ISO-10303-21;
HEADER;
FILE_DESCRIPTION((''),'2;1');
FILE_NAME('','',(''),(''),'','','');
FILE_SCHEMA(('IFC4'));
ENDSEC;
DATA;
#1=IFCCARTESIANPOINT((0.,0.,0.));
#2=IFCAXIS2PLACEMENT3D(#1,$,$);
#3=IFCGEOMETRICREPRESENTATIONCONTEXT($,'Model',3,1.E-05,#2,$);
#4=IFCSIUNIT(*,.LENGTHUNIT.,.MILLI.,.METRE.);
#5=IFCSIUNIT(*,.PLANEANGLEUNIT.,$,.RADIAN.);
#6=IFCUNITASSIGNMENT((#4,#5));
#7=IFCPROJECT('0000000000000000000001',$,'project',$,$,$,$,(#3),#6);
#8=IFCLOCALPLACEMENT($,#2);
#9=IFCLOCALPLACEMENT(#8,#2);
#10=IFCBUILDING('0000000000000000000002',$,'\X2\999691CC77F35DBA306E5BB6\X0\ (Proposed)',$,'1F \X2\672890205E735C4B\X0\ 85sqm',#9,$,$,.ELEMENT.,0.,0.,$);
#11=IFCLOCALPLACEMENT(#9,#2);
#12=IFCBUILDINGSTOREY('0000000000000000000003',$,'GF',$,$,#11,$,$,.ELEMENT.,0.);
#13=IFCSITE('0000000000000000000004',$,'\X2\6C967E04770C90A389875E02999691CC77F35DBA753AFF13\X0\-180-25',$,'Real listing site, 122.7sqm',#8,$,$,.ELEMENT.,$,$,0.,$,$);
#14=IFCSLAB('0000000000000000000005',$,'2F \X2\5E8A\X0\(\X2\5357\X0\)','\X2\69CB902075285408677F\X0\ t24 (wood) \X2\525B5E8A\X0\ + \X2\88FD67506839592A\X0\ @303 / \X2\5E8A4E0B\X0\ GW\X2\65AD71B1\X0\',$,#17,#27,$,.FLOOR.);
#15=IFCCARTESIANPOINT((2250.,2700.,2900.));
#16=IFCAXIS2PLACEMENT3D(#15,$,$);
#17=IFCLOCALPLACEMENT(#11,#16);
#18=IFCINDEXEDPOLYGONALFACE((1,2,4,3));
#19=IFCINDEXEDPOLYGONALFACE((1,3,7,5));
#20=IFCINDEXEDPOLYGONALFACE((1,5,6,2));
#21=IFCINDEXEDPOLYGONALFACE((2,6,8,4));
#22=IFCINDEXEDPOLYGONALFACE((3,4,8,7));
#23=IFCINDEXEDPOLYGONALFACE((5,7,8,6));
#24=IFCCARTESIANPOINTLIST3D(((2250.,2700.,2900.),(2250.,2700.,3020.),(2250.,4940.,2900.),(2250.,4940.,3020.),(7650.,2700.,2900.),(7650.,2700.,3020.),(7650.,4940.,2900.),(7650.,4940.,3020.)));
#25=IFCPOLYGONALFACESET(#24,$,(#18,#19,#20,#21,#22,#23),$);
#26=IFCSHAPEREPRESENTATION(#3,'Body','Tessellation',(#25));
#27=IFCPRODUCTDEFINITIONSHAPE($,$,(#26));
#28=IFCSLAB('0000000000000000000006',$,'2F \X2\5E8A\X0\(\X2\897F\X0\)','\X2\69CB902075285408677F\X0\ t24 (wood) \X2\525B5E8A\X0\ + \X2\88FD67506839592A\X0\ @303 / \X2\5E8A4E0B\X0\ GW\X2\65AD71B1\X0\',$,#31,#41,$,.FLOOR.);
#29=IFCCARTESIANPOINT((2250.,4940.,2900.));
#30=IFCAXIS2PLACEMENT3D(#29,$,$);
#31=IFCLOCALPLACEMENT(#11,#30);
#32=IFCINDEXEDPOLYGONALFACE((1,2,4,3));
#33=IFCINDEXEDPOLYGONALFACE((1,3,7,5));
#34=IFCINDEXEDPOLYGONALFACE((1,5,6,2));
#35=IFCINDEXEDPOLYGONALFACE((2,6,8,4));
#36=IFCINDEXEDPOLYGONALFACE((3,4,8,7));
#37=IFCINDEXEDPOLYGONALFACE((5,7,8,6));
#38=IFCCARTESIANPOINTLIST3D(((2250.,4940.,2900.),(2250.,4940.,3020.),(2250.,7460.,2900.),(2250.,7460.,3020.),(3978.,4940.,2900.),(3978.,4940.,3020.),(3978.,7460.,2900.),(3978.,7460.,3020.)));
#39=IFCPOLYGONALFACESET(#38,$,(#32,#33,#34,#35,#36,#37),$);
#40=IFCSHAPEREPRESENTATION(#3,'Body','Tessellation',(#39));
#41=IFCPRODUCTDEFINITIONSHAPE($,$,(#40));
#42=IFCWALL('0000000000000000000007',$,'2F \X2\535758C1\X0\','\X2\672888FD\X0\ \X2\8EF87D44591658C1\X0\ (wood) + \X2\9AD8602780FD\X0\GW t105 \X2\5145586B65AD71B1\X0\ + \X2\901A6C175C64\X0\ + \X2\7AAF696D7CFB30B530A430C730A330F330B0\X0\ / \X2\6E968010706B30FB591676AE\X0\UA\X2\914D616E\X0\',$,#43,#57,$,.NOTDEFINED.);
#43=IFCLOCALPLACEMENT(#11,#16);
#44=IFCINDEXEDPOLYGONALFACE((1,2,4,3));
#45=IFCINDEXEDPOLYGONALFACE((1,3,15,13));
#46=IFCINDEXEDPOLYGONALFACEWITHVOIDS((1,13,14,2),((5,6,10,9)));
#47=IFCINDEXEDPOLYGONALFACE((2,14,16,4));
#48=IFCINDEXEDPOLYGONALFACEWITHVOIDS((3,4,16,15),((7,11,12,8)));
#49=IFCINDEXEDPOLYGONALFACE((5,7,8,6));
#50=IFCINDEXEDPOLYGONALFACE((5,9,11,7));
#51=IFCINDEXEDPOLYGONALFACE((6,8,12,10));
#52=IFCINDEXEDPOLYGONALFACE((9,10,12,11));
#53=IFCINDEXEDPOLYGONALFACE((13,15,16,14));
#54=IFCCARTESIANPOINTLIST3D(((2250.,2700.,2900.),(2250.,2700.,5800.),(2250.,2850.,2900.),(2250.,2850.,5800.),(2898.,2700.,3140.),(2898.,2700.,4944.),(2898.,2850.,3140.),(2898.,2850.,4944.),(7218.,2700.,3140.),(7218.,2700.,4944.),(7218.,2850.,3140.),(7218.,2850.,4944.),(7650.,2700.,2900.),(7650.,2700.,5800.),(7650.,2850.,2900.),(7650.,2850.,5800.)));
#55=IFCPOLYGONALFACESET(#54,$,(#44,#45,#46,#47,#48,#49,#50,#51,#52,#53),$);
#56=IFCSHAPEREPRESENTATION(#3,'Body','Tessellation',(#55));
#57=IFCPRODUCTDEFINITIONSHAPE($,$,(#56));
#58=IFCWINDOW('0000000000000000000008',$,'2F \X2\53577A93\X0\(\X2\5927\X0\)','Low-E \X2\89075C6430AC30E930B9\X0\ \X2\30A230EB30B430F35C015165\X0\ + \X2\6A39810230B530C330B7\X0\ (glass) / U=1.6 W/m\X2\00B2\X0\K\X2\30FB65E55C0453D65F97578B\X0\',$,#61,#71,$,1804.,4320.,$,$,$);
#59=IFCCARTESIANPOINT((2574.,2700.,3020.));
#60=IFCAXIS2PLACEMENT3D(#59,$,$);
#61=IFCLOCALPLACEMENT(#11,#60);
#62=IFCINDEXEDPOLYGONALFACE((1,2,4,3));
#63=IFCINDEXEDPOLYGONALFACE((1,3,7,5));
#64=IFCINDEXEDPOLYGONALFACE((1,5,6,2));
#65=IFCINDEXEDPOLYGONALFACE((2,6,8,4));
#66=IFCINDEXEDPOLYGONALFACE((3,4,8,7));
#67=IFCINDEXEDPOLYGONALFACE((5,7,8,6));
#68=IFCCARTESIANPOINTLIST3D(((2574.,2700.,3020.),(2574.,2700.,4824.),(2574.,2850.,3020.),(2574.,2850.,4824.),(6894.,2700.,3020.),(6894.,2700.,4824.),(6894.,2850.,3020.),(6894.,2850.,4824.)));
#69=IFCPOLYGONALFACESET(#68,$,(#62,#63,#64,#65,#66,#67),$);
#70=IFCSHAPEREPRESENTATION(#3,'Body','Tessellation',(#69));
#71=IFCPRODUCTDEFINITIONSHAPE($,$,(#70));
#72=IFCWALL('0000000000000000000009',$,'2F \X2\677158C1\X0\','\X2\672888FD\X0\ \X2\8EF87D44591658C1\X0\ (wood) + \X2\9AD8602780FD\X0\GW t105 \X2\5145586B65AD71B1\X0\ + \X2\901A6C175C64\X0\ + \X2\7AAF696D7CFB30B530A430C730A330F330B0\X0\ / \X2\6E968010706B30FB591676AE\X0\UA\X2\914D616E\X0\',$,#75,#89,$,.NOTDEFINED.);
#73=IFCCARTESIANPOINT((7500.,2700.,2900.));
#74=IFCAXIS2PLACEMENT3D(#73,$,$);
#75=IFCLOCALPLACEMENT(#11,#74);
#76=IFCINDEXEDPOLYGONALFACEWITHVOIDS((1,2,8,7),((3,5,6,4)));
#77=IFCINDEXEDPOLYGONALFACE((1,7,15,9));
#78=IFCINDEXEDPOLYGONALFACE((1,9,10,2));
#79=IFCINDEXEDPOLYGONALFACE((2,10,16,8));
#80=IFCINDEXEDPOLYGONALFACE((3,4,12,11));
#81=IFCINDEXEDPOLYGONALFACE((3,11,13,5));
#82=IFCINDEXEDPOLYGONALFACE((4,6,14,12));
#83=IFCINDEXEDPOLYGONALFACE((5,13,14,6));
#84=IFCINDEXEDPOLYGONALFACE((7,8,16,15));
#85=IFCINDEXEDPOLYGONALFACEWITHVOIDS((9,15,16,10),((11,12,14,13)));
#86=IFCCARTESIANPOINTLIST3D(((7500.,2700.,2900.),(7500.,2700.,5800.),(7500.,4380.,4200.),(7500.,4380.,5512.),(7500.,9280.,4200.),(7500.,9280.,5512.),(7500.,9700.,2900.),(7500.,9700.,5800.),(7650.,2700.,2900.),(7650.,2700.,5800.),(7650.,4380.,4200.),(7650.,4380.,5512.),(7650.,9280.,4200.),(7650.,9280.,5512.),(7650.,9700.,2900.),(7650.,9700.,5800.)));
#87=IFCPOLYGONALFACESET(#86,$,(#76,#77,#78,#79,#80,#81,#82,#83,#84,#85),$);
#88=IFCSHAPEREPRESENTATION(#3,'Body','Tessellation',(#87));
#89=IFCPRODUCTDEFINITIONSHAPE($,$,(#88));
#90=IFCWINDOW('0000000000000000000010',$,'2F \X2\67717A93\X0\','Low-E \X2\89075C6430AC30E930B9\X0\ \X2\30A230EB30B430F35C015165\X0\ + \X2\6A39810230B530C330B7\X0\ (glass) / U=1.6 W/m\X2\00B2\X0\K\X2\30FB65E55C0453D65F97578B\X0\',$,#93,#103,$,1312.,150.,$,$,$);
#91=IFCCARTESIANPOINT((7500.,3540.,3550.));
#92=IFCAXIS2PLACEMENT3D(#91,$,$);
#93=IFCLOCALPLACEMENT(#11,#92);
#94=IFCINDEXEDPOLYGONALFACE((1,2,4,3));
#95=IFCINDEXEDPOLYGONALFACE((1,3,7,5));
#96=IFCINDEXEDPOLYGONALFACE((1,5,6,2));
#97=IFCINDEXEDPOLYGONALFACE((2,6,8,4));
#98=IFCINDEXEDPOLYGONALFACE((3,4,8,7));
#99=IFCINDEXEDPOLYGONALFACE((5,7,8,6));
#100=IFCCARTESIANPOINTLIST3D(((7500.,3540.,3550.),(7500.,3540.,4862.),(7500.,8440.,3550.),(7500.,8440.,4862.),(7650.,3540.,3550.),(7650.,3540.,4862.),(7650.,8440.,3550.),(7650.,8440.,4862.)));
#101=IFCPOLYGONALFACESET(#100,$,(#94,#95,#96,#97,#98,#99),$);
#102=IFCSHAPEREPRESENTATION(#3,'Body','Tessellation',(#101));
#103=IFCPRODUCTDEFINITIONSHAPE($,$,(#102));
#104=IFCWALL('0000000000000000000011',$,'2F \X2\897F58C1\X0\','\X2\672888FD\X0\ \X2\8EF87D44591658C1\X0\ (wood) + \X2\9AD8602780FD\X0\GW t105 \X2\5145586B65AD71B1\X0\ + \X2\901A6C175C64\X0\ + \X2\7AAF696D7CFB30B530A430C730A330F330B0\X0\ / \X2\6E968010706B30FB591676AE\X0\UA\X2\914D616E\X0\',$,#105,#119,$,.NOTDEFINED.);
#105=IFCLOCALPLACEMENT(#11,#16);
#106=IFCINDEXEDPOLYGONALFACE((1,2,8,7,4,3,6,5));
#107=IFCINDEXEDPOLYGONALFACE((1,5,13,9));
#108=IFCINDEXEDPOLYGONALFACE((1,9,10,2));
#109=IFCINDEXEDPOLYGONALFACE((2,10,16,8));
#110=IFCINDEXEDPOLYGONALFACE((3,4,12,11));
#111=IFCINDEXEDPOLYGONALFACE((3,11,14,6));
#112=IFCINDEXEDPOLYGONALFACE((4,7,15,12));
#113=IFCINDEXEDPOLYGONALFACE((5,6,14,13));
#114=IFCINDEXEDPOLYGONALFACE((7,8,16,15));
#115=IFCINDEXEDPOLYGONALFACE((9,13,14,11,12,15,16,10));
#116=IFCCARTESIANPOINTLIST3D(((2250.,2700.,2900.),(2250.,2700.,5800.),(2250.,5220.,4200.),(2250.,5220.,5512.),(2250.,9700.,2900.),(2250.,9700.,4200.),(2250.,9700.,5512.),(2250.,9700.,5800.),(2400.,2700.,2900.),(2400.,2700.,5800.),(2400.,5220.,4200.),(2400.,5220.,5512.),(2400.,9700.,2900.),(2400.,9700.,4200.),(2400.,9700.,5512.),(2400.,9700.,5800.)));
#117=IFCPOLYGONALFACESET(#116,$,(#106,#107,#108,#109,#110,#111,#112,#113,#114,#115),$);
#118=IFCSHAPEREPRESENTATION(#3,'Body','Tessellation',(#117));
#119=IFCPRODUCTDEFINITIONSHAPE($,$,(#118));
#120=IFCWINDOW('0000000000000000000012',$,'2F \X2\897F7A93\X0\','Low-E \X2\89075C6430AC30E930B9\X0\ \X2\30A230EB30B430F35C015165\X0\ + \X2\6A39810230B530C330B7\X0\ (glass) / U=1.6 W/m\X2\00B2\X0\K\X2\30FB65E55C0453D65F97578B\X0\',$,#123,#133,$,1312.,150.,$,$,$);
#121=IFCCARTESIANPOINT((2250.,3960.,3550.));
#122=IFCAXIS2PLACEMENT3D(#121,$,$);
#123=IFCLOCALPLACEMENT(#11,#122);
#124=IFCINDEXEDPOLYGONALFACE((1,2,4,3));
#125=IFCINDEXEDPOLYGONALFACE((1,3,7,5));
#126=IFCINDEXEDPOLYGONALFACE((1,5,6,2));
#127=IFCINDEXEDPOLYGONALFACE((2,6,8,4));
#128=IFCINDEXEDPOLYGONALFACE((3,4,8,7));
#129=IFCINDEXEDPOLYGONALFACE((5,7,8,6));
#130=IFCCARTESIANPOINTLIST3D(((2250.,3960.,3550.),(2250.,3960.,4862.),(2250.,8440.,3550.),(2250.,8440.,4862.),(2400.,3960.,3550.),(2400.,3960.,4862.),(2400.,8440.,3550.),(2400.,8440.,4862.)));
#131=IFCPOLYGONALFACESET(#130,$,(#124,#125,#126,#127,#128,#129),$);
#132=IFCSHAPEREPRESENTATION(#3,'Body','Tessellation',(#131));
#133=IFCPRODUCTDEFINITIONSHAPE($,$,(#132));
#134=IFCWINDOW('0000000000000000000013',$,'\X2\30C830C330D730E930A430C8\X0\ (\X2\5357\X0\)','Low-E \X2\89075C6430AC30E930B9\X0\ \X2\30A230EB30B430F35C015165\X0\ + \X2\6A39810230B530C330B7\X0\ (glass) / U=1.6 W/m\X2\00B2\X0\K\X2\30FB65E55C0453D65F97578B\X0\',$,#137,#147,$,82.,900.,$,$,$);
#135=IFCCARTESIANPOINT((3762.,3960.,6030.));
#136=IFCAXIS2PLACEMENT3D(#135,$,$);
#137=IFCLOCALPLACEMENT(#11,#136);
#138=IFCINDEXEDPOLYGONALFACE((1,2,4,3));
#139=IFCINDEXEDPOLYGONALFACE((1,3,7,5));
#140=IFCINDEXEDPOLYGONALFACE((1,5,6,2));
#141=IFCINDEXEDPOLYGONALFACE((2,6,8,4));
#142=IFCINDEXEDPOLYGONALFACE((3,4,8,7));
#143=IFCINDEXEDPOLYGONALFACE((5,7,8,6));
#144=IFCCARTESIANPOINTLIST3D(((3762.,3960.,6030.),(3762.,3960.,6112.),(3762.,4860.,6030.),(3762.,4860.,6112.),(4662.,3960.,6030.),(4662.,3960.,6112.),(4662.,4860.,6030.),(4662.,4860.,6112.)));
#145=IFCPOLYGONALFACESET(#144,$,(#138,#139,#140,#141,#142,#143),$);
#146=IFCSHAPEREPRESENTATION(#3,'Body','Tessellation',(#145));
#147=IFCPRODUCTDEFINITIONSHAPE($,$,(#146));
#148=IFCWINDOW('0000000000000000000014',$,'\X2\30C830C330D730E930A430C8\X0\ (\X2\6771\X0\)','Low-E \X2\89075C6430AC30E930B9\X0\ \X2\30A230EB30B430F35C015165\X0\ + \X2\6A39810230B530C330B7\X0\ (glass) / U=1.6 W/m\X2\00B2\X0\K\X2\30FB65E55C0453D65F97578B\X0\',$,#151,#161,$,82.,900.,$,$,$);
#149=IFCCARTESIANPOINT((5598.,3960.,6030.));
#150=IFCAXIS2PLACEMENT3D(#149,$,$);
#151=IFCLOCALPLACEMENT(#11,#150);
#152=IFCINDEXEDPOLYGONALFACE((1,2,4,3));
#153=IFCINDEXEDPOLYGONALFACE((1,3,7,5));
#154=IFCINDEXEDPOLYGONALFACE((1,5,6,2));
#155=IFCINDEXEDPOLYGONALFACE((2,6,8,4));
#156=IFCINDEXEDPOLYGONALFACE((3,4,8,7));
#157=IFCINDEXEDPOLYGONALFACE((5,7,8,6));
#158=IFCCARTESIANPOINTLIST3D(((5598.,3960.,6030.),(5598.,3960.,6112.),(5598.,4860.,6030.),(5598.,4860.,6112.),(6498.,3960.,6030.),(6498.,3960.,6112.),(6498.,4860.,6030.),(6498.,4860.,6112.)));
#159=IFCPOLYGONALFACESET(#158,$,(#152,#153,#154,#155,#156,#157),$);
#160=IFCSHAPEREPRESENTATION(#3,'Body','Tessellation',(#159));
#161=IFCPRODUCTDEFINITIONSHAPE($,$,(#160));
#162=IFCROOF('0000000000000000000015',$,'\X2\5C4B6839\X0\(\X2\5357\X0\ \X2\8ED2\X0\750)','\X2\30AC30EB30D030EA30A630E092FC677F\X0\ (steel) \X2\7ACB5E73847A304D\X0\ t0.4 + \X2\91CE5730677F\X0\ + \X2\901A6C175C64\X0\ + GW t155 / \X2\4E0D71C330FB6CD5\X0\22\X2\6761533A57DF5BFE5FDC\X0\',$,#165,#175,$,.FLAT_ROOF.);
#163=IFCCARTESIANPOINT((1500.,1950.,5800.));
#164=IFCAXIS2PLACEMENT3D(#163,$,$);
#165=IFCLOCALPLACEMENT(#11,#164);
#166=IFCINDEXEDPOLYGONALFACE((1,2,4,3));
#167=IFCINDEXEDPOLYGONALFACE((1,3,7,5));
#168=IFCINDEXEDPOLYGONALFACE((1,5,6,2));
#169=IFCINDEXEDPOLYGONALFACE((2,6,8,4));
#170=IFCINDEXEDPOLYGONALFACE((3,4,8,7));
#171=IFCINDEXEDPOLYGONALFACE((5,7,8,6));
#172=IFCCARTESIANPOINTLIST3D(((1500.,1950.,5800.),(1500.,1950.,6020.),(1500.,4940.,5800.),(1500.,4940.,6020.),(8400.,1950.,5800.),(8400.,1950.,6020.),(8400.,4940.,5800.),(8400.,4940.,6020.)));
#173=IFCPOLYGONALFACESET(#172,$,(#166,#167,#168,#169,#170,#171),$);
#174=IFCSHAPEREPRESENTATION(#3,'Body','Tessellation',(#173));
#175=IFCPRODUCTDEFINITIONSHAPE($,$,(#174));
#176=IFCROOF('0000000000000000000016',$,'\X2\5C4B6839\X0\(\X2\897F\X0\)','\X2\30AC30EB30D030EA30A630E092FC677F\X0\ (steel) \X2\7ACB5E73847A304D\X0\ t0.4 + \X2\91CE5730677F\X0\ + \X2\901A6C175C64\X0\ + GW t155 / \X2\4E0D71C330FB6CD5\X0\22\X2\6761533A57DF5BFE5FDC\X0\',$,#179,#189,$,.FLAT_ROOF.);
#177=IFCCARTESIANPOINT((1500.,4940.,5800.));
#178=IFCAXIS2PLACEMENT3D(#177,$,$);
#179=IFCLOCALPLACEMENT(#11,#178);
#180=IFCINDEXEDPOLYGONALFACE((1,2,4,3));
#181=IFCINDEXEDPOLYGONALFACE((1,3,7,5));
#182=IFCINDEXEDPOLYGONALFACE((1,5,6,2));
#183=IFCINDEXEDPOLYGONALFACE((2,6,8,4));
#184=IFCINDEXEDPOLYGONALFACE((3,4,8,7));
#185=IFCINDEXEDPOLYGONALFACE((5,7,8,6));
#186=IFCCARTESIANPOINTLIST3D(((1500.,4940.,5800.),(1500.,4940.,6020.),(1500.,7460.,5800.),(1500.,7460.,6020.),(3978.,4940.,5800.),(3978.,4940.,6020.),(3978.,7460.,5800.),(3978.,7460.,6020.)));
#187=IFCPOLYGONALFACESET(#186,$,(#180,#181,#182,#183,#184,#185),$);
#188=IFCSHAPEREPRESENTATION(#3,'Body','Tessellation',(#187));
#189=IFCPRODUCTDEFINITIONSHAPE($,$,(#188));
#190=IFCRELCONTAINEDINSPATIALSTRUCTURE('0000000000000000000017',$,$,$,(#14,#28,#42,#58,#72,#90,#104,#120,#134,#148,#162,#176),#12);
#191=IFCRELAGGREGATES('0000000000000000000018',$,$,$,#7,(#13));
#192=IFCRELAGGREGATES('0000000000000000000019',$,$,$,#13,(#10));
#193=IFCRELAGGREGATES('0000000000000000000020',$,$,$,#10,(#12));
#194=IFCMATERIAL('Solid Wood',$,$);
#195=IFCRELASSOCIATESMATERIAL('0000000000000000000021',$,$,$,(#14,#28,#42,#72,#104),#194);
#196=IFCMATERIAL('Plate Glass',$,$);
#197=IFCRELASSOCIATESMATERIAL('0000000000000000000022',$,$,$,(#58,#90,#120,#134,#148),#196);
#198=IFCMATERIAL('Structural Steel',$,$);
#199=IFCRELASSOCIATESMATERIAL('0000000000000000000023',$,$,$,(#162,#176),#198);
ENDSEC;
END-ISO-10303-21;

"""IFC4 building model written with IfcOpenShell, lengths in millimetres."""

from ifc_helpers import new_model, si_unit, frame, frame_2d, origin, place, context, project, spatial, rectangle, extrude, material, element, fill, save


model = new_model("IFC4")

# Units and contexts
model_context = context("Model", 3, precision=1e-05, world=origin())
ifc_project = project(units=[si_unit("LENGTHUNIT", "METRE", prefix="MILLI"), si_unit("PLANEANGLEUNIT", "RADIAN")], contexts=[model_context])

# Site, building, storey
site_placement = place(None, origin())
site = spatial("IfcSite", under=ifc_project, at=site_placement, Name="沖縄県那覇市首里石嶺町３-180-25", ObjectType="Real listing site, 122.7sqm", CompositionType="ELEMENT", RefElevation=0.0)
building_placement = place(site_placement, origin())
building = spatial("IfcBuilding", under=site, at=building_placement, Name="首里石嶺の家 (Proposed)", ObjectType="1F 木造平屋 85sqm", CompositionType="ELEMENT", ElevationOfRefHeight=0.0, ElevationOfTerrain=0.0)
storey_placement = place(building_placement, origin())
storey = spatial("IfcBuildingStorey", under=building, at=storey_placement, Name="GF", CompositionType="ELEMENT", Elevation=0.0)

# Slabs
ifc_material_1 = material(Name="Solid Wood")
slab_1_placement = place(storey_placement, frame((2250.0, 2700.0, 2900.0)))
element("IfcSlab", 1, at=slab_1_placement, inside=storey, material=ifc_material_1, Name="2F 床(南)", Description="構造用合板 t24 (wood) 剛床 + 製材根太 @303 / 床下 GW断熱", PredefinedType="FLOOR", context=model_context, shape_type="SweptSolid", body=[
    extrude(rectangle(XDim=5400.0, YDim=2240.0, at=frame_2d((2700.0, 1120.0))), frame((2250.0, 2700.0, 2900.0)), (0.0, 0.0, 1.0), 120.0),
])
slab_2_placement = place(storey_placement, frame((2250.0, 4940.0, 2900.0)))
element("IfcSlab", 2, at=slab_2_placement, inside=storey, material=ifc_material_1, Name="2F 床(西)", Description="構造用合板 t24 (wood) 剛床 + 製材根太 @303 / 床下 GW断熱", PredefinedType="FLOOR", context=model_context, shape_type="SweptSolid", body=[
    extrude(rectangle(XDim=1728.0, YDim=2520.0, at=frame_2d((864.0, 1260.0))), frame((2250.0, 4940.0, 2900.0)), (0.0, 0.0, 1.0), 120.0),
])

# Walls, openings, windows
wall_1_placement = place(storey_placement, frame((2250.0, 2700.0, 2900.0)))
wall_1 = element("IfcWall", 3, at=wall_1_placement, inside=storey, material=ifc_material_1, Name="2F 南壁", Description="木製 軸組外壁 (wood) + 高性能GW t105 充填断熱 + 通気層 + 窯業系サイディング / 準耐火・外皮UA配慮", PredefinedType="NOTDEFINED", context=model_context, shape_type="SweptSolid", body=[
    extrude(rectangle(XDim=5400.0, YDim=150.0, at=frame_2d((2700.0, 75.0))), frame((2250.0, 2700.0, 2900.0)), (0.0, 0.0, 1.0), 2900.0),
])
opening_1_placement = place(storey_placement, frame((2574.0, 2700.0, 3020.0)))
opening_1 = element("IfcOpeningElement", 4, at=opening_1_placement, cuts=wall_1, PredefinedType="NOTDEFINED", context=model_context, shape_type="SweptSolid", body=[
    extrude(rectangle(XDim=4320.0, YDim=150.0, at=frame_2d((2160.0, 75.0))), frame((2574.0, 2700.0, 3020.0)), (0.0, 0.0, 1.0), 1804.0),
])
ifc_material_2 = material(Name="Plate Glass")
window_1_placement = place(storey_placement, frame((2574.0, 2700.0, 3020.0)))
window_1 = element("IfcWindow", 5, at=window_1_placement, inside=storey, material=ifc_material_2, Name="2F 南窓(大)", Description="Low-E 複層ガラス アルゴン封入 + 樹脂サッシ (glass) / U=1.6 W/m²K・日射取得型", OverallHeight=1804.0, OverallWidth=4320.0, context=model_context, shape_type="SweptSolid", body=[
    extrude(rectangle(XDim=4320.0, YDim=150.0, at=frame_2d((2160.0, 75.0))), frame((2574.0, 2700.0, 3020.0)), (0.0, 0.0, 1.0), 1804.0),
])
fill(opening_1, window_1)
wall_2_placement = place(storey_placement, frame((7500.0, 2700.0, 2900.0)))
wall_2 = element("IfcWall", 6, at=wall_2_placement, inside=storey, material=ifc_material_1, Name="2F 東壁", Description="木製 軸組外壁 (wood) + 高性能GW t105 充填断熱 + 通気層 + 窯業系サイディング / 準耐火・外皮UA配慮", PredefinedType="NOTDEFINED", context=model_context, shape_type="SweptSolid", body=[
    extrude(rectangle(XDim=150.0, YDim=7000.0, at=frame_2d((75.0, 3500.0))), frame((7500.0, 2700.0, 2900.0)), (0.0, 0.0, 1.0), 2900.0),
])
opening_2_placement = place(storey_placement, frame((7500.0, 3540.0, 3550.0)))
opening_2 = element("IfcOpeningElement", 7, at=opening_2_placement, cuts=wall_2, PredefinedType="NOTDEFINED", context=model_context, shape_type="SweptSolid", body=[
    extrude(rectangle(XDim=150.0, YDim=4900.0, at=frame_2d((75.0, 2450.0))), frame((7500.0, 3540.0, 3550.0)), (0.0, 0.0, 1.0), 1312.0),
])
window_2_placement = place(storey_placement, frame((7500.0, 3540.0, 3550.0)))
window_2 = element("IfcWindow", 8, at=window_2_placement, inside=storey, material=ifc_material_2, Name="2F 東窓", Description="Low-E 複層ガラス アルゴン封入 + 樹脂サッシ (glass) / U=1.6 W/m²K・日射取得型", OverallHeight=1312.0, OverallWidth=150.0, context=model_context, shape_type="SweptSolid", body=[
    extrude(rectangle(XDim=150.0, YDim=4900.0, at=frame_2d((75.0, 2450.0))), frame((7500.0, 3540.0, 3550.0)), (0.0, 0.0, 1.0), 1312.0),
])
fill(opening_2, window_2)
wall_3_placement = place(storey_placement, frame((2250.0, 2700.0, 2900.0)))
wall_3 = element("IfcWall", 9, at=wall_3_placement, inside=storey, material=ifc_material_1, Name="2F 西壁", Description="木製 軸組外壁 (wood) + 高性能GW t105 充填断熱 + 通気層 + 窯業系サイディング / 準耐火・外皮UA配慮", PredefinedType="NOTDEFINED", context=model_context, shape_type="SweptSolid", body=[
    extrude(rectangle(XDim=150.0, YDim=7000.0, at=frame_2d((75.0, 3500.0))), frame((2250.0, 2700.0, 2900.0)), (0.0, 0.0, 1.0), 2900.0),
])
opening_3_placement = place(storey_placement, frame((2250.0, 3960.0, 3550.0)))
opening_3 = element("IfcOpeningElement", 10, at=opening_3_placement, cuts=wall_3, PredefinedType="NOTDEFINED", context=model_context, shape_type="SweptSolid", body=[
    extrude(rectangle(XDim=150.0, YDim=4480.0, at=frame_2d((75.0, 2240.0))), frame((2250.0, 3960.0, 3550.0)), (0.0, 0.0, 1.0), 1312.0),
])
window_3_placement = place(storey_placement, frame((2250.0, 3960.0, 3550.0)))
window_3 = element("IfcWindow", 11, at=window_3_placement, inside=storey, material=ifc_material_2, Name="2F 西窓", Description="Low-E 複層ガラス アルゴン封入 + 樹脂サッシ (glass) / U=1.6 W/m²K・日射取得型", OverallHeight=1312.0, OverallWidth=150.0, context=model_context, shape_type="SweptSolid", body=[
    extrude(rectangle(XDim=150.0, YDim=4480.0, at=frame_2d((75.0, 2240.0))), frame((2250.0, 3960.0, 3550.0)), (0.0, 0.0, 1.0), 1312.0),
])
fill(opening_3, window_3)

# Windows
window_4_placement = place(storey_placement, frame((3762.0, 3960.0, 6030.0)))
element("IfcWindow", 12, at=window_4_placement, inside=storey, material=ifc_material_2, Name="トップライト (南)", Description="Low-E 複層ガラス アルゴン封入 + 樹脂サッシ (glass) / U=1.6 W/m²K・日射取得型", OverallHeight=82.0, OverallWidth=900.0, context=model_context, shape_type="SweptSolid", body=[
    extrude(rectangle(XDim=900.0, YDim=900.0, at=frame_2d((450.0, 450.0))), frame((3762.0, 3960.0, 6030.0)), (0.0, 0.0, 1.0), 82.0),
])
window_5_placement = place(storey_placement, frame((5598.0, 3960.0, 6030.0)))
element("IfcWindow", 13, at=window_5_placement, inside=storey, material=ifc_material_2, Name="トップライト (東)", Description="Low-E 複層ガラス アルゴン封入 + 樹脂サッシ (glass) / U=1.6 W/m²K・日射取得型", OverallHeight=82.0, OverallWidth=900.0, context=model_context, shape_type="SweptSolid", body=[
    extrude(rectangle(XDim=900.0, YDim=900.0, at=frame_2d((450.0, 450.0))), frame((5598.0, 3960.0, 6030.0)), (0.0, 0.0, 1.0), 82.0),
])

# Roofs
ifc_material_3 = material(Name="Structural Steel")
roof_1_placement = place(storey_placement, frame((1500.0, 1950.0, 5800.0)))
element("IfcRoof", 14, at=roof_1_placement, inside=storey, material=ifc_material_3, Name="屋根(南 軒750)", Description="ガルバリウム鋼板 (steel) 立平葺き t0.4 + 野地板 + 通気層 + GW t155 / 不燃・法22条区域対応", PredefinedType="FLAT_ROOF", context=model_context, shape_type="SweptSolid", body=[
    extrude(rectangle(XDim=6900.0, YDim=2990.0, at=frame_2d((3450.0, 1495.0))), frame((1500.0, 1950.0, 5800.0)), (0.0, 0.0, 1.0), 220.0),
])
roof_2_placement = place(storey_placement, frame((1500.0, 4940.0, 5800.0)))
element("IfcRoof", 15, at=roof_2_placement, inside=storey, material=ifc_material_3, Name="屋根(西)", Description="ガルバリウム鋼板 (steel) 立平葺き t0.4 + 野地板 + 通気層 + GW t155 / 不燃・法22条区域対応", PredefinedType="FLAT_ROOF", context=model_context, shape_type="SweptSolid", body=[
    extrude(rectangle(XDim=2478.0, YDim=2520.0, at=frame_2d((1239.0, 1260.0))), frame((1500.0, 4940.0, 5800.0)), (0.0, 0.0, 1.0), 220.0),
])

save(model, "model.ifc")
